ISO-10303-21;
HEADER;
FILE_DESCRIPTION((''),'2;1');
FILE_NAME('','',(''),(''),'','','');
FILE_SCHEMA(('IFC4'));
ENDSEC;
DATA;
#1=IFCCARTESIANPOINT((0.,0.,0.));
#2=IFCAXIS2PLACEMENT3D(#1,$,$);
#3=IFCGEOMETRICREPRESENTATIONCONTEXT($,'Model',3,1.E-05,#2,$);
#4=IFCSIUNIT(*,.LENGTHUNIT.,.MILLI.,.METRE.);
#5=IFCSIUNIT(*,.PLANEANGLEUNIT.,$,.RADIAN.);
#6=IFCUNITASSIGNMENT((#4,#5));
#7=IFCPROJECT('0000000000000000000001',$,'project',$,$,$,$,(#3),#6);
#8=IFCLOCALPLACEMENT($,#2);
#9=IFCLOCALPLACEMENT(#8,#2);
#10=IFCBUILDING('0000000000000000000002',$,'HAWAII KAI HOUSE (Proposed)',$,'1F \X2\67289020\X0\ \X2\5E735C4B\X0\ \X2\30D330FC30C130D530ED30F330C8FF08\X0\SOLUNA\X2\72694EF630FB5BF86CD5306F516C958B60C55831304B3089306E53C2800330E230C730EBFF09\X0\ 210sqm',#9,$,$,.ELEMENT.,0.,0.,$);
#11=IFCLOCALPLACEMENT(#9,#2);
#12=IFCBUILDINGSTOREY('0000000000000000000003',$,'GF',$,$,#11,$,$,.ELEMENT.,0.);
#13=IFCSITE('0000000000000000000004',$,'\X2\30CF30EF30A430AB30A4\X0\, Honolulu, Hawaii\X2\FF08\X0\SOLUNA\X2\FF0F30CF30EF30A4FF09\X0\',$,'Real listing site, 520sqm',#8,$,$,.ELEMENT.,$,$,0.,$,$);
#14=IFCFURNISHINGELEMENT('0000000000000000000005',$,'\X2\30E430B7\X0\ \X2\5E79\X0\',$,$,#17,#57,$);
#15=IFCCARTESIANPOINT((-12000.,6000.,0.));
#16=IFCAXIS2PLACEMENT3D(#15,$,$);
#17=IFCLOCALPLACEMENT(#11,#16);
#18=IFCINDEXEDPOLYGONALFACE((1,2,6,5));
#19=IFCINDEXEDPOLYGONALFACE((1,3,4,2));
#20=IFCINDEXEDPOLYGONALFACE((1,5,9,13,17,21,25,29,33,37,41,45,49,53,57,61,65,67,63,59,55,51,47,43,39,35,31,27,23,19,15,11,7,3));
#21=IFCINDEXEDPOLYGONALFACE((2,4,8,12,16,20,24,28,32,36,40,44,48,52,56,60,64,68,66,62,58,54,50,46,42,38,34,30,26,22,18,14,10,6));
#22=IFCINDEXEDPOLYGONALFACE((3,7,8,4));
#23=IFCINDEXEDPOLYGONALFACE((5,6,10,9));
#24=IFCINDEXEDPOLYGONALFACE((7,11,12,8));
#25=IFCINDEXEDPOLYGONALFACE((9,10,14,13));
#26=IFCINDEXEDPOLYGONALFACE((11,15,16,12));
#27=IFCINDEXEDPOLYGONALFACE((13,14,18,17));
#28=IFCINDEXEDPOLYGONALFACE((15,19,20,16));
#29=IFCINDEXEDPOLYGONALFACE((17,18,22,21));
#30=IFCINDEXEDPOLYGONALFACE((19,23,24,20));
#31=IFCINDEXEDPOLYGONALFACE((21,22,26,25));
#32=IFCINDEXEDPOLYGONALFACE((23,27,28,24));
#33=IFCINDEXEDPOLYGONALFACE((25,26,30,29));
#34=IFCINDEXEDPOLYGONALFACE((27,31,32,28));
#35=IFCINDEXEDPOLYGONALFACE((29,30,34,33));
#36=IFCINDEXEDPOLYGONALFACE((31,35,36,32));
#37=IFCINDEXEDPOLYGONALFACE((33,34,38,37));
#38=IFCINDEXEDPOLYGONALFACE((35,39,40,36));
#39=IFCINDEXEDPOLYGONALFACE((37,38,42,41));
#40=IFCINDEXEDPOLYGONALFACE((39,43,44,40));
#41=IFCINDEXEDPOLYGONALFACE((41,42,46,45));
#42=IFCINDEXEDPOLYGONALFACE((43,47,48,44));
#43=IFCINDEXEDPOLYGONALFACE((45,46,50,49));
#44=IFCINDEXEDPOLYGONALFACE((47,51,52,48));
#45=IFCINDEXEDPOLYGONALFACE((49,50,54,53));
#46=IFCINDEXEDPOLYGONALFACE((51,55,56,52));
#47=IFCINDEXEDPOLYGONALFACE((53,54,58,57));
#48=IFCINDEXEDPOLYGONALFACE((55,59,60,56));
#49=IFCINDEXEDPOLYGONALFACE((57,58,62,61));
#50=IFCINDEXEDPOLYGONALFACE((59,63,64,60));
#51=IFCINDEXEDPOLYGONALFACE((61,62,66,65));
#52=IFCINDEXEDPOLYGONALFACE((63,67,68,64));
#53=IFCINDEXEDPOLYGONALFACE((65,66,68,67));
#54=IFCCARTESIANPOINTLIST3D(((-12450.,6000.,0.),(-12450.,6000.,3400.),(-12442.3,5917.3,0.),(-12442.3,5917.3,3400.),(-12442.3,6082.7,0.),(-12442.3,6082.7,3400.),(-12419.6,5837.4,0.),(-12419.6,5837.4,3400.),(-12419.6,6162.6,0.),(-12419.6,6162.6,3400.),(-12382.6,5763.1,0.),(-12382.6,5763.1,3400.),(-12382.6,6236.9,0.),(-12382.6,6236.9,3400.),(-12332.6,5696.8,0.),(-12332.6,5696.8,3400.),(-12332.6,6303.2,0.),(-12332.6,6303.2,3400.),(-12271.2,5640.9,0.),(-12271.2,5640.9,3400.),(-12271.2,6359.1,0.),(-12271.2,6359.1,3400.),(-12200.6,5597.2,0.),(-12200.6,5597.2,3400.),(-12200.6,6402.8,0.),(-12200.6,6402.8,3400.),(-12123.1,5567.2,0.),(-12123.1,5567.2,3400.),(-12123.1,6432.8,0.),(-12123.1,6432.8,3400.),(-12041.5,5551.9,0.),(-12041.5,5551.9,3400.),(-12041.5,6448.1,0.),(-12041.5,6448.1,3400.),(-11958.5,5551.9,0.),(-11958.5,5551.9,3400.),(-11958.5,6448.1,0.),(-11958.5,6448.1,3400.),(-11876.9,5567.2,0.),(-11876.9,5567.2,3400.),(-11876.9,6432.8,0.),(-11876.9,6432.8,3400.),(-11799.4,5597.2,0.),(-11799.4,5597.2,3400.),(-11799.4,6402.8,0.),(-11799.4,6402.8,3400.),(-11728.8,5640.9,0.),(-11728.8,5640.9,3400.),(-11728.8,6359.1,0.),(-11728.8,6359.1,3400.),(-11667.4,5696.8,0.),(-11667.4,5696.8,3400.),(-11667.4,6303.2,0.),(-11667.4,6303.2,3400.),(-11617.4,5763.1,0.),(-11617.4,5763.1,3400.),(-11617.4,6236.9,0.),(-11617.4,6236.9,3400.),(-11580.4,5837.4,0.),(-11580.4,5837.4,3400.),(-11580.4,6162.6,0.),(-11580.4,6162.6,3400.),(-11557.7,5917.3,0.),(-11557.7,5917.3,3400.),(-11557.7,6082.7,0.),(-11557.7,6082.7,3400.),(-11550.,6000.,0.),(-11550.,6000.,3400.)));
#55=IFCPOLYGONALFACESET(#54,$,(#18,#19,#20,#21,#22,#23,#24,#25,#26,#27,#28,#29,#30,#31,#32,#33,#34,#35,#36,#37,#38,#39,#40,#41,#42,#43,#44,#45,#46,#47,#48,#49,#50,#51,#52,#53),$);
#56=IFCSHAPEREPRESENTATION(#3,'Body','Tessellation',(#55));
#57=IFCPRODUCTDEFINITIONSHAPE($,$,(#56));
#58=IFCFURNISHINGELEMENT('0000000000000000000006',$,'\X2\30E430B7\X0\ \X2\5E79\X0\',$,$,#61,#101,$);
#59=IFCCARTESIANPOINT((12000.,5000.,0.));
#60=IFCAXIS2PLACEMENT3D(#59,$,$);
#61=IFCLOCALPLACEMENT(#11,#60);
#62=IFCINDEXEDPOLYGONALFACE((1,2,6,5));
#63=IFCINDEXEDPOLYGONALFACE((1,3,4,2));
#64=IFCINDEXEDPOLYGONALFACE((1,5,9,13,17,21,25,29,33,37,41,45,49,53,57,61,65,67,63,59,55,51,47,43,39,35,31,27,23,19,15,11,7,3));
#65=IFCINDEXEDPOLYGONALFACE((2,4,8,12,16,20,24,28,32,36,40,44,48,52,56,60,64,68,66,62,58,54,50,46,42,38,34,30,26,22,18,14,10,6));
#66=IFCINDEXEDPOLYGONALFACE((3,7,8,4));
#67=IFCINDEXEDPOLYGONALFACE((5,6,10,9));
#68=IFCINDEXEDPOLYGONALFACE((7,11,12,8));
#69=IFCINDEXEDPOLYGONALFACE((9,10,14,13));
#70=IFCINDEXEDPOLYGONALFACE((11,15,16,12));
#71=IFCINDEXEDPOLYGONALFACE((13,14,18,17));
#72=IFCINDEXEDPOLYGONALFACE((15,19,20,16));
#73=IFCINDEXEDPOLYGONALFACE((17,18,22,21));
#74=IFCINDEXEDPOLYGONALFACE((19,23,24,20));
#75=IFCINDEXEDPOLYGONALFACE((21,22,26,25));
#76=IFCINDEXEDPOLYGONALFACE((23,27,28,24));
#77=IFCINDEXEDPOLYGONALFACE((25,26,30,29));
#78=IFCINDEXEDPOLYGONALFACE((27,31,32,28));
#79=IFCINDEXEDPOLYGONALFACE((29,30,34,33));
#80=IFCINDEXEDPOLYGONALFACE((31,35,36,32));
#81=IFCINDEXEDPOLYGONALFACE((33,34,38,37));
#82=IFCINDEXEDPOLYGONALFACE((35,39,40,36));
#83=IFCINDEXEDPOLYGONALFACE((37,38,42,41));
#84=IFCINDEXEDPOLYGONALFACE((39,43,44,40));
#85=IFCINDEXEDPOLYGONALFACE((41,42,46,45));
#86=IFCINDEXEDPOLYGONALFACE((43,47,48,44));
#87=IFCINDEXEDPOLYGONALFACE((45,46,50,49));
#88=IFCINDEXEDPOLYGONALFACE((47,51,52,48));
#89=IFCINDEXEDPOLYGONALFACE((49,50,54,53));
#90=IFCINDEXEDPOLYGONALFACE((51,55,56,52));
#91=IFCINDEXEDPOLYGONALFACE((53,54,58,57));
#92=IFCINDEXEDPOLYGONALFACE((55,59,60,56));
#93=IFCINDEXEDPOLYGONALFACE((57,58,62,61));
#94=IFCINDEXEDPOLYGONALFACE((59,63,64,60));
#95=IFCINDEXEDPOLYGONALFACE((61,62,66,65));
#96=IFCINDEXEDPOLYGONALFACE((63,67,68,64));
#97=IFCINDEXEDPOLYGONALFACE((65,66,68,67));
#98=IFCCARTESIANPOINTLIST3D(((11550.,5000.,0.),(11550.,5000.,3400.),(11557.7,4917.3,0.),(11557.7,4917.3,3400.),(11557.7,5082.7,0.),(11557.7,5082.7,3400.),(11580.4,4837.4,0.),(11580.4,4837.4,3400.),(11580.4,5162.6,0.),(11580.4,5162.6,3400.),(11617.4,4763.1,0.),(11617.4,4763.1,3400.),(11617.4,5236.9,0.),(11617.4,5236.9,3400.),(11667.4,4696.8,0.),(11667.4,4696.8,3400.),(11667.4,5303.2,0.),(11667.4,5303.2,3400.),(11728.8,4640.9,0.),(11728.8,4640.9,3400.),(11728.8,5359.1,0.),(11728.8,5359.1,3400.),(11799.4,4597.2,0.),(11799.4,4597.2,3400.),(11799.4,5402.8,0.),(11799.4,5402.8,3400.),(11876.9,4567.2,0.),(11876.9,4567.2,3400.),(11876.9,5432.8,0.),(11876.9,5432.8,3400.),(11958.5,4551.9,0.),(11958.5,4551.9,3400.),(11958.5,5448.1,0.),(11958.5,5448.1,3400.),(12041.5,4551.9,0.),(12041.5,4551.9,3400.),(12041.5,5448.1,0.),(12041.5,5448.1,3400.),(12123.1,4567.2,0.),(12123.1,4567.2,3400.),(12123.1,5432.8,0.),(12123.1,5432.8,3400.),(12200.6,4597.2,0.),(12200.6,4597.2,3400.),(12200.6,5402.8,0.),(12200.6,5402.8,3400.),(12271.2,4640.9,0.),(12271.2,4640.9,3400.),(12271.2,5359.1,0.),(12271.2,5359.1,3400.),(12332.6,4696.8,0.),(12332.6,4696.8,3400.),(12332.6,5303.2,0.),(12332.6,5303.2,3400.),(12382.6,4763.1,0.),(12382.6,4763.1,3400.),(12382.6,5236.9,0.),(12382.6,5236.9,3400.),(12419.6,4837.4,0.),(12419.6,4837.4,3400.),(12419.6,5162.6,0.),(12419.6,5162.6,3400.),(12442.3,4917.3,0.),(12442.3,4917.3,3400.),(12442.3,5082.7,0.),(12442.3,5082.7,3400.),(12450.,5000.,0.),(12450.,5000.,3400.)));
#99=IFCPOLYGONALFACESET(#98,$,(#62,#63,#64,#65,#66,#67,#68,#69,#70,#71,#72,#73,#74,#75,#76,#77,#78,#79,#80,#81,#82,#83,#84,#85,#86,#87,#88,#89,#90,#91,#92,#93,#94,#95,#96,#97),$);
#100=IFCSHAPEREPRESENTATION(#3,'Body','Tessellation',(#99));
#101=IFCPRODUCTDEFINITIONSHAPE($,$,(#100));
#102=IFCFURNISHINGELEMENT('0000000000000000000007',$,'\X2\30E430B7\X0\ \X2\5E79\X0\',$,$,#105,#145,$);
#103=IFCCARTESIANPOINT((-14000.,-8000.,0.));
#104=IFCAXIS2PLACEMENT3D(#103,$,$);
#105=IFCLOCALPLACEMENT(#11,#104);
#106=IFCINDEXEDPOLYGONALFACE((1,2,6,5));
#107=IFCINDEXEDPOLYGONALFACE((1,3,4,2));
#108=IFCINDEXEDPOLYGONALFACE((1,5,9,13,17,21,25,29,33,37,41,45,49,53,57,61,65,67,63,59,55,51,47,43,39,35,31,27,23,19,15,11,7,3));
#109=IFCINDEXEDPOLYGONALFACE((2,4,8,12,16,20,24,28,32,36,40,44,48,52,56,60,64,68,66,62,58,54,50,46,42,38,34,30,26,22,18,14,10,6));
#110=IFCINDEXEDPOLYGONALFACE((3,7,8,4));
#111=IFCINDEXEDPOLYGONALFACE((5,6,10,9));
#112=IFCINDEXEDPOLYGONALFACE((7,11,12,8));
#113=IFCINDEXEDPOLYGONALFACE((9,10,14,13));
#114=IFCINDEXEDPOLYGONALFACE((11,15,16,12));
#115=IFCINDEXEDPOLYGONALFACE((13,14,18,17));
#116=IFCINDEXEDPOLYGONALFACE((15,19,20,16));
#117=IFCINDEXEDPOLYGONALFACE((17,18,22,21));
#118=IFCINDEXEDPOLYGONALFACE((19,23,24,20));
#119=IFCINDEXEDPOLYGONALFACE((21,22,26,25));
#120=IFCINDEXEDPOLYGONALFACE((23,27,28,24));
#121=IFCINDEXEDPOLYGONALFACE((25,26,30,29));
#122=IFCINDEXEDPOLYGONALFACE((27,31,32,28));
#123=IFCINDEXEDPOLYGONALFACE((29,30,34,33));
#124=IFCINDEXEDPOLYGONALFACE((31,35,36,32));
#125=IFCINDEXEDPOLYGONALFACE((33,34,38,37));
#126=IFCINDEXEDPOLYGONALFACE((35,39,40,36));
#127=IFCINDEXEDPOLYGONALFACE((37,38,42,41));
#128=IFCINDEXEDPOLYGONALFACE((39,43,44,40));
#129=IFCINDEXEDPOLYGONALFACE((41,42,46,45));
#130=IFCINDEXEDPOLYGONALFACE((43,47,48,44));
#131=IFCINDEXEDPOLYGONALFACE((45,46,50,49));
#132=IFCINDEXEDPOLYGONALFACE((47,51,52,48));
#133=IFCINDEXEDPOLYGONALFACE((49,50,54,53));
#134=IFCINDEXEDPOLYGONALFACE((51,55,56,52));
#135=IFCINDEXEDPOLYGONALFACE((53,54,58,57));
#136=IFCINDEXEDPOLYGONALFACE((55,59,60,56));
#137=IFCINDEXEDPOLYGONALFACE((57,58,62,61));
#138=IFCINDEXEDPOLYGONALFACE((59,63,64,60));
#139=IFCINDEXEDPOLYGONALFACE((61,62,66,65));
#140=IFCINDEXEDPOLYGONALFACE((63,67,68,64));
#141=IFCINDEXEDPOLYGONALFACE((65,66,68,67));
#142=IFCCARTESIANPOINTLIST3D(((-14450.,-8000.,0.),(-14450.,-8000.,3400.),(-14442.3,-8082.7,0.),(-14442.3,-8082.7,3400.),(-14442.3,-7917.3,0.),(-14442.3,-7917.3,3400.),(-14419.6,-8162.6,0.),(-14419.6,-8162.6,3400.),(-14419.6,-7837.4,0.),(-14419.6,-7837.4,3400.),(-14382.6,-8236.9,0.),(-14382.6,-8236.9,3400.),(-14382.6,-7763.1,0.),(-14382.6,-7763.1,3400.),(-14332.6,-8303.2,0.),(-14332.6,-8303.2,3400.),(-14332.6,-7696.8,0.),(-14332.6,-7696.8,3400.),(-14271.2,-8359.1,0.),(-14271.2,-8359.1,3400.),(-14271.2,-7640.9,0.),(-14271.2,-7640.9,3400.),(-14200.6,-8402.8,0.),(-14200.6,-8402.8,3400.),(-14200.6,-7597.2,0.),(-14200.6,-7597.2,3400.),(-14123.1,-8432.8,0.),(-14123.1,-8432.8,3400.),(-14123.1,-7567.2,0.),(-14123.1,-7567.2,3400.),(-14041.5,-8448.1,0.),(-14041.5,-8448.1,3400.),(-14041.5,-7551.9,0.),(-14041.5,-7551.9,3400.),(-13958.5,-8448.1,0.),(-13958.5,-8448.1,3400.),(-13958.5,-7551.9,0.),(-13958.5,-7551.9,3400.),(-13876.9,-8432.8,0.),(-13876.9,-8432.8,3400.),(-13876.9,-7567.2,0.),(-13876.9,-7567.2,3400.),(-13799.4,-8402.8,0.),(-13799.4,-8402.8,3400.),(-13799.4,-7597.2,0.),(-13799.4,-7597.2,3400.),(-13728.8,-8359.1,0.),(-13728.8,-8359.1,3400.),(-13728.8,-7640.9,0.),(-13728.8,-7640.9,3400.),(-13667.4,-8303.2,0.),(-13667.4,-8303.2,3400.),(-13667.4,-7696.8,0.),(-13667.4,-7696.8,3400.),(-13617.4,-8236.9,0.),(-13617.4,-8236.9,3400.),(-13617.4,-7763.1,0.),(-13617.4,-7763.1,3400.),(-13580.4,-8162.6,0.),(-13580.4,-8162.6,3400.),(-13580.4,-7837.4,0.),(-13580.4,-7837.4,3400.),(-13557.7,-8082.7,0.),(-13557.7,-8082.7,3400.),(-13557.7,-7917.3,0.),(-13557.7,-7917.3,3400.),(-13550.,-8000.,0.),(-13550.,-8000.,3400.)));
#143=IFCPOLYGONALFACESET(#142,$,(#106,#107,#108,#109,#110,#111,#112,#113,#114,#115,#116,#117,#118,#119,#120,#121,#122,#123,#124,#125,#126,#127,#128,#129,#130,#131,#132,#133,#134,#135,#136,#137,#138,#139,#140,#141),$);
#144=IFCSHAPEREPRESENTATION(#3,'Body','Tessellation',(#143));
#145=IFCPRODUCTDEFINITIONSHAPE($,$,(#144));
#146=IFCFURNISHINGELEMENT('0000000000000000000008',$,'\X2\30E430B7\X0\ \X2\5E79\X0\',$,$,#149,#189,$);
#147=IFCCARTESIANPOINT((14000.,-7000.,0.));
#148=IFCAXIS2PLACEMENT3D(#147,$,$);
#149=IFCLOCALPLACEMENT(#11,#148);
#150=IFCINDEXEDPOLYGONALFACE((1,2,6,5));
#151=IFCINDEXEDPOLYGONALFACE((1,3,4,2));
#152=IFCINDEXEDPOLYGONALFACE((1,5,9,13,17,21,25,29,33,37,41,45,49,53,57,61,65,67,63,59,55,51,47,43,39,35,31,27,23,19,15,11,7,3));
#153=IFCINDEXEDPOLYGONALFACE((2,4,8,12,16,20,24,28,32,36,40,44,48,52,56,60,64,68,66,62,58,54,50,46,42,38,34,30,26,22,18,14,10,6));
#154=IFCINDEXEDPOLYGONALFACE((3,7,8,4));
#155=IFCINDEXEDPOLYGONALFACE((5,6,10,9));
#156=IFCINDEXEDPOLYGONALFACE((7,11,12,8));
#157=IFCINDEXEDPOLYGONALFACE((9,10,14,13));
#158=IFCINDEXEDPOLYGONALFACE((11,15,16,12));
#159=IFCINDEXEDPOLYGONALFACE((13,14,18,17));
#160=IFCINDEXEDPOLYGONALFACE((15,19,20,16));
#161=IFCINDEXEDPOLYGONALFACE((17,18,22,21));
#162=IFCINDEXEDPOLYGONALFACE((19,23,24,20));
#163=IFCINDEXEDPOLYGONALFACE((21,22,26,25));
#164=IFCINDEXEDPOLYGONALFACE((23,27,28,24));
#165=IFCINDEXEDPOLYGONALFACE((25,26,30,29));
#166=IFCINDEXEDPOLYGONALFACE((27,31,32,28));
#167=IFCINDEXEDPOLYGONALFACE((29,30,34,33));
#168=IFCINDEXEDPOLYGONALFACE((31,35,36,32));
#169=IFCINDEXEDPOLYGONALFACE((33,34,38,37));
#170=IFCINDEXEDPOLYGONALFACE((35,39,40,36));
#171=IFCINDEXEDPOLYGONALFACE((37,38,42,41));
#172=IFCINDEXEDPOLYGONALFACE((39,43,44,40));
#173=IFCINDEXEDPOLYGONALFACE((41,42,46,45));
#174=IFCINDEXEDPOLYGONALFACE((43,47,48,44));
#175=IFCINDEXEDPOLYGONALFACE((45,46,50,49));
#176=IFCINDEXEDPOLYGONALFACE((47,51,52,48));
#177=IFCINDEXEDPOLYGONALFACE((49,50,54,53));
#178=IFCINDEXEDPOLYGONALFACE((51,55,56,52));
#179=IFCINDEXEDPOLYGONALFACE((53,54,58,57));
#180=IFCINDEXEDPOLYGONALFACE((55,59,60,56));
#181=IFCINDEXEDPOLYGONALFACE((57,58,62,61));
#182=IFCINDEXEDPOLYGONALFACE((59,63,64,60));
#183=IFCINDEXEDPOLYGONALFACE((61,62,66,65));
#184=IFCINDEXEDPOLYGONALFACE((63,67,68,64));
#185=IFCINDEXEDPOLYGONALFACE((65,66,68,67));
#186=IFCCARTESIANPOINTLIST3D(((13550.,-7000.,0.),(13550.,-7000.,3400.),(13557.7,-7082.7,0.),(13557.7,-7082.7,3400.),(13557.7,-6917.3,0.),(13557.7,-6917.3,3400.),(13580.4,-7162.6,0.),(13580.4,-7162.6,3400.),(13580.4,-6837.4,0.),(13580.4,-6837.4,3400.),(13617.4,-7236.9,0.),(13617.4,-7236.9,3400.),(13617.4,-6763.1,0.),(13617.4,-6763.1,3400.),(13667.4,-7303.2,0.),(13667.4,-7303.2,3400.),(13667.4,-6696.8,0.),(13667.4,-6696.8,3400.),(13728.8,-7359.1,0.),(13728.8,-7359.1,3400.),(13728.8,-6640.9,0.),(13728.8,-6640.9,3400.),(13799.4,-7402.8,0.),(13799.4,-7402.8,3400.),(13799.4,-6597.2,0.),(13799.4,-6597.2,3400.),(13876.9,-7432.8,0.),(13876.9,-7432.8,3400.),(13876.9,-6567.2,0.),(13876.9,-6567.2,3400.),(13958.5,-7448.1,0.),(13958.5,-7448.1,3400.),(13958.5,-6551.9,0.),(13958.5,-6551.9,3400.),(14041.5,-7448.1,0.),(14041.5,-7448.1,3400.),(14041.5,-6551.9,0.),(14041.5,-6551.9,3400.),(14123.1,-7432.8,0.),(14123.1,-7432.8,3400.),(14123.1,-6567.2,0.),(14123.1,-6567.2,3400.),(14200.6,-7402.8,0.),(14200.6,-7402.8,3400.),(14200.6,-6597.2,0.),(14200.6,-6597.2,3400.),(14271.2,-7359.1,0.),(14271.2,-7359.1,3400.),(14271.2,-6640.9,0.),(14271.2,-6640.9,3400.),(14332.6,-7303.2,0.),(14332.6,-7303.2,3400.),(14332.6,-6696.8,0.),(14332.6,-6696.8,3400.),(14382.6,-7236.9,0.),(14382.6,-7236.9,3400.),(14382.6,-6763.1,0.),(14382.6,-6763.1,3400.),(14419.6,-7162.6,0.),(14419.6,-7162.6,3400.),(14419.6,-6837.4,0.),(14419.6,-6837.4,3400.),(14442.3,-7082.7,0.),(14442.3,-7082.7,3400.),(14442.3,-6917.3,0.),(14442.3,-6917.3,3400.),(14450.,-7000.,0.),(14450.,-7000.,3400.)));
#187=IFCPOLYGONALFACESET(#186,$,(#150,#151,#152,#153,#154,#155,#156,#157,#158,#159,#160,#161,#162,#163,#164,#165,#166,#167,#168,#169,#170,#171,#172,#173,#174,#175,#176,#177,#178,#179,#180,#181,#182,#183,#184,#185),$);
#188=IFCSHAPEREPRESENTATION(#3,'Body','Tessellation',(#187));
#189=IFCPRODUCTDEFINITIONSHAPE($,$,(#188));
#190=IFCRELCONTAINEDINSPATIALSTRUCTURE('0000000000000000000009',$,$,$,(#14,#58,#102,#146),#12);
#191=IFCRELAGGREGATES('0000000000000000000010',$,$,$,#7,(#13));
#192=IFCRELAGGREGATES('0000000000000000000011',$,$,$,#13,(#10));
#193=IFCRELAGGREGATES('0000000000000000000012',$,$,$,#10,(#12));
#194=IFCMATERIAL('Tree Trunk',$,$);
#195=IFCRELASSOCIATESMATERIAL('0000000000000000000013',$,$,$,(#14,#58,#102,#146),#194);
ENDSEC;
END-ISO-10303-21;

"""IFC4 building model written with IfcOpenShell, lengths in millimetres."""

from ifc_helpers import new_model, si_unit, frame, origin, origin_2d, place, context, project, spatial, circle, extrude, material, element, save


model = new_model("IFC4")

# Units and contexts
model_context = context("Model", 3, precision=1e-05, world=origin())
ifc_project = project(units=[si_unit("LENGTHUNIT", "METRE", prefix="MILLI"), si_unit("PLANEANGLEUNIT", "RADIAN")], contexts=[model_context])

# Site, building, storey
site_placement = place(None, origin())
site = spatial("IfcSite", under=ifc_project, at=site_placement, Name="ハワイカイ, Honolulu, Hawaii（SOLUNA／ハワイ）", ObjectType="Real listing site, 520sqm", CompositionType="ELEMENT", RefElevation=0.0)
building_placement = place(site_placement, origin())
building = spatial("IfcBuilding", under=site, at=building_placement, Name="HAWAII KAI HOUSE (Proposed)", ObjectType="1F 木造 平屋 ビーチフロント（SOLUNA物件・寸法は公開情報からの参考モデル） 210sqm", CompositionType="ELEMENT", ElevationOfRefHeight=0.0, ElevationOfTerrain=0.0)
storey_placement = place(building_placement, origin())
storey = spatial("IfcBuildingStorey", under=building, at=storey_placement, Name="GF", CompositionType="ELEMENT", Elevation=0.0)

# Furnishing elements
ifc_material_1 = material(Name="Tree Trunk")
furnishing_1_placement = place(storey_placement, frame((-12000.0, 6000.0, 0.0)))
element("IfcFurnishingElement", 1, at=furnishing_1_placement, inside=storey, material=ifc_material_1, Name="ヤシ 幹", context=model_context, shape_type="SweptSolid", body=[
    extrude(circle(Radius=450.0, at=origin_2d()), frame((-12000.0, 6000.0, 0.0)), (0.0, 0.0, 1.0), 3400.0),
])
furnishing_2_placement = place(storey_placement, frame((12000.0, 5000.0, 0.0)))
element("IfcFurnishingElement", 2, at=furnishing_2_placement, inside=storey, material=ifc_material_1, Name="ヤシ 幹", context=model_context, shape_type="SweptSolid", body=[
    extrude(circle(Radius=450.0, at=origin_2d()), frame((12000.0, 5000.0, 0.0)), (0.0, 0.0, 1.0), 3400.0),
])
furnishing_3_placement = place(storey_placement, frame((-14000.0, -8000.0, 0.0)))
element("IfcFurnishingElement", 3, at=furnishing_3_placement, inside=storey, material=ifc_material_1, Name="ヤシ 幹", context=model_context, shape_type="SweptSolid", body=[
    extrude(circle(Radius=450.0, at=origin_2d()), frame((-14000.0, -8000.0, 0.0)), (0.0, 0.0, 1.0), 3400.0),
])
furnishing_4_placement = place(storey_placement, frame((14000.0, -7000.0, 0.0)))
element("IfcFurnishingElement", 4, at=furnishing_4_placement, inside=storey, material=ifc_material_1, Name="ヤシ 幹", context=model_context, shape_type="SweptSolid", body=[
    extrude(circle(Radius=450.0, at=origin_2d()), frame((14000.0, -7000.0, 0.0)), (0.0, 0.0, 1.0), 3400.0),
])

save(model, "model.ifc")
